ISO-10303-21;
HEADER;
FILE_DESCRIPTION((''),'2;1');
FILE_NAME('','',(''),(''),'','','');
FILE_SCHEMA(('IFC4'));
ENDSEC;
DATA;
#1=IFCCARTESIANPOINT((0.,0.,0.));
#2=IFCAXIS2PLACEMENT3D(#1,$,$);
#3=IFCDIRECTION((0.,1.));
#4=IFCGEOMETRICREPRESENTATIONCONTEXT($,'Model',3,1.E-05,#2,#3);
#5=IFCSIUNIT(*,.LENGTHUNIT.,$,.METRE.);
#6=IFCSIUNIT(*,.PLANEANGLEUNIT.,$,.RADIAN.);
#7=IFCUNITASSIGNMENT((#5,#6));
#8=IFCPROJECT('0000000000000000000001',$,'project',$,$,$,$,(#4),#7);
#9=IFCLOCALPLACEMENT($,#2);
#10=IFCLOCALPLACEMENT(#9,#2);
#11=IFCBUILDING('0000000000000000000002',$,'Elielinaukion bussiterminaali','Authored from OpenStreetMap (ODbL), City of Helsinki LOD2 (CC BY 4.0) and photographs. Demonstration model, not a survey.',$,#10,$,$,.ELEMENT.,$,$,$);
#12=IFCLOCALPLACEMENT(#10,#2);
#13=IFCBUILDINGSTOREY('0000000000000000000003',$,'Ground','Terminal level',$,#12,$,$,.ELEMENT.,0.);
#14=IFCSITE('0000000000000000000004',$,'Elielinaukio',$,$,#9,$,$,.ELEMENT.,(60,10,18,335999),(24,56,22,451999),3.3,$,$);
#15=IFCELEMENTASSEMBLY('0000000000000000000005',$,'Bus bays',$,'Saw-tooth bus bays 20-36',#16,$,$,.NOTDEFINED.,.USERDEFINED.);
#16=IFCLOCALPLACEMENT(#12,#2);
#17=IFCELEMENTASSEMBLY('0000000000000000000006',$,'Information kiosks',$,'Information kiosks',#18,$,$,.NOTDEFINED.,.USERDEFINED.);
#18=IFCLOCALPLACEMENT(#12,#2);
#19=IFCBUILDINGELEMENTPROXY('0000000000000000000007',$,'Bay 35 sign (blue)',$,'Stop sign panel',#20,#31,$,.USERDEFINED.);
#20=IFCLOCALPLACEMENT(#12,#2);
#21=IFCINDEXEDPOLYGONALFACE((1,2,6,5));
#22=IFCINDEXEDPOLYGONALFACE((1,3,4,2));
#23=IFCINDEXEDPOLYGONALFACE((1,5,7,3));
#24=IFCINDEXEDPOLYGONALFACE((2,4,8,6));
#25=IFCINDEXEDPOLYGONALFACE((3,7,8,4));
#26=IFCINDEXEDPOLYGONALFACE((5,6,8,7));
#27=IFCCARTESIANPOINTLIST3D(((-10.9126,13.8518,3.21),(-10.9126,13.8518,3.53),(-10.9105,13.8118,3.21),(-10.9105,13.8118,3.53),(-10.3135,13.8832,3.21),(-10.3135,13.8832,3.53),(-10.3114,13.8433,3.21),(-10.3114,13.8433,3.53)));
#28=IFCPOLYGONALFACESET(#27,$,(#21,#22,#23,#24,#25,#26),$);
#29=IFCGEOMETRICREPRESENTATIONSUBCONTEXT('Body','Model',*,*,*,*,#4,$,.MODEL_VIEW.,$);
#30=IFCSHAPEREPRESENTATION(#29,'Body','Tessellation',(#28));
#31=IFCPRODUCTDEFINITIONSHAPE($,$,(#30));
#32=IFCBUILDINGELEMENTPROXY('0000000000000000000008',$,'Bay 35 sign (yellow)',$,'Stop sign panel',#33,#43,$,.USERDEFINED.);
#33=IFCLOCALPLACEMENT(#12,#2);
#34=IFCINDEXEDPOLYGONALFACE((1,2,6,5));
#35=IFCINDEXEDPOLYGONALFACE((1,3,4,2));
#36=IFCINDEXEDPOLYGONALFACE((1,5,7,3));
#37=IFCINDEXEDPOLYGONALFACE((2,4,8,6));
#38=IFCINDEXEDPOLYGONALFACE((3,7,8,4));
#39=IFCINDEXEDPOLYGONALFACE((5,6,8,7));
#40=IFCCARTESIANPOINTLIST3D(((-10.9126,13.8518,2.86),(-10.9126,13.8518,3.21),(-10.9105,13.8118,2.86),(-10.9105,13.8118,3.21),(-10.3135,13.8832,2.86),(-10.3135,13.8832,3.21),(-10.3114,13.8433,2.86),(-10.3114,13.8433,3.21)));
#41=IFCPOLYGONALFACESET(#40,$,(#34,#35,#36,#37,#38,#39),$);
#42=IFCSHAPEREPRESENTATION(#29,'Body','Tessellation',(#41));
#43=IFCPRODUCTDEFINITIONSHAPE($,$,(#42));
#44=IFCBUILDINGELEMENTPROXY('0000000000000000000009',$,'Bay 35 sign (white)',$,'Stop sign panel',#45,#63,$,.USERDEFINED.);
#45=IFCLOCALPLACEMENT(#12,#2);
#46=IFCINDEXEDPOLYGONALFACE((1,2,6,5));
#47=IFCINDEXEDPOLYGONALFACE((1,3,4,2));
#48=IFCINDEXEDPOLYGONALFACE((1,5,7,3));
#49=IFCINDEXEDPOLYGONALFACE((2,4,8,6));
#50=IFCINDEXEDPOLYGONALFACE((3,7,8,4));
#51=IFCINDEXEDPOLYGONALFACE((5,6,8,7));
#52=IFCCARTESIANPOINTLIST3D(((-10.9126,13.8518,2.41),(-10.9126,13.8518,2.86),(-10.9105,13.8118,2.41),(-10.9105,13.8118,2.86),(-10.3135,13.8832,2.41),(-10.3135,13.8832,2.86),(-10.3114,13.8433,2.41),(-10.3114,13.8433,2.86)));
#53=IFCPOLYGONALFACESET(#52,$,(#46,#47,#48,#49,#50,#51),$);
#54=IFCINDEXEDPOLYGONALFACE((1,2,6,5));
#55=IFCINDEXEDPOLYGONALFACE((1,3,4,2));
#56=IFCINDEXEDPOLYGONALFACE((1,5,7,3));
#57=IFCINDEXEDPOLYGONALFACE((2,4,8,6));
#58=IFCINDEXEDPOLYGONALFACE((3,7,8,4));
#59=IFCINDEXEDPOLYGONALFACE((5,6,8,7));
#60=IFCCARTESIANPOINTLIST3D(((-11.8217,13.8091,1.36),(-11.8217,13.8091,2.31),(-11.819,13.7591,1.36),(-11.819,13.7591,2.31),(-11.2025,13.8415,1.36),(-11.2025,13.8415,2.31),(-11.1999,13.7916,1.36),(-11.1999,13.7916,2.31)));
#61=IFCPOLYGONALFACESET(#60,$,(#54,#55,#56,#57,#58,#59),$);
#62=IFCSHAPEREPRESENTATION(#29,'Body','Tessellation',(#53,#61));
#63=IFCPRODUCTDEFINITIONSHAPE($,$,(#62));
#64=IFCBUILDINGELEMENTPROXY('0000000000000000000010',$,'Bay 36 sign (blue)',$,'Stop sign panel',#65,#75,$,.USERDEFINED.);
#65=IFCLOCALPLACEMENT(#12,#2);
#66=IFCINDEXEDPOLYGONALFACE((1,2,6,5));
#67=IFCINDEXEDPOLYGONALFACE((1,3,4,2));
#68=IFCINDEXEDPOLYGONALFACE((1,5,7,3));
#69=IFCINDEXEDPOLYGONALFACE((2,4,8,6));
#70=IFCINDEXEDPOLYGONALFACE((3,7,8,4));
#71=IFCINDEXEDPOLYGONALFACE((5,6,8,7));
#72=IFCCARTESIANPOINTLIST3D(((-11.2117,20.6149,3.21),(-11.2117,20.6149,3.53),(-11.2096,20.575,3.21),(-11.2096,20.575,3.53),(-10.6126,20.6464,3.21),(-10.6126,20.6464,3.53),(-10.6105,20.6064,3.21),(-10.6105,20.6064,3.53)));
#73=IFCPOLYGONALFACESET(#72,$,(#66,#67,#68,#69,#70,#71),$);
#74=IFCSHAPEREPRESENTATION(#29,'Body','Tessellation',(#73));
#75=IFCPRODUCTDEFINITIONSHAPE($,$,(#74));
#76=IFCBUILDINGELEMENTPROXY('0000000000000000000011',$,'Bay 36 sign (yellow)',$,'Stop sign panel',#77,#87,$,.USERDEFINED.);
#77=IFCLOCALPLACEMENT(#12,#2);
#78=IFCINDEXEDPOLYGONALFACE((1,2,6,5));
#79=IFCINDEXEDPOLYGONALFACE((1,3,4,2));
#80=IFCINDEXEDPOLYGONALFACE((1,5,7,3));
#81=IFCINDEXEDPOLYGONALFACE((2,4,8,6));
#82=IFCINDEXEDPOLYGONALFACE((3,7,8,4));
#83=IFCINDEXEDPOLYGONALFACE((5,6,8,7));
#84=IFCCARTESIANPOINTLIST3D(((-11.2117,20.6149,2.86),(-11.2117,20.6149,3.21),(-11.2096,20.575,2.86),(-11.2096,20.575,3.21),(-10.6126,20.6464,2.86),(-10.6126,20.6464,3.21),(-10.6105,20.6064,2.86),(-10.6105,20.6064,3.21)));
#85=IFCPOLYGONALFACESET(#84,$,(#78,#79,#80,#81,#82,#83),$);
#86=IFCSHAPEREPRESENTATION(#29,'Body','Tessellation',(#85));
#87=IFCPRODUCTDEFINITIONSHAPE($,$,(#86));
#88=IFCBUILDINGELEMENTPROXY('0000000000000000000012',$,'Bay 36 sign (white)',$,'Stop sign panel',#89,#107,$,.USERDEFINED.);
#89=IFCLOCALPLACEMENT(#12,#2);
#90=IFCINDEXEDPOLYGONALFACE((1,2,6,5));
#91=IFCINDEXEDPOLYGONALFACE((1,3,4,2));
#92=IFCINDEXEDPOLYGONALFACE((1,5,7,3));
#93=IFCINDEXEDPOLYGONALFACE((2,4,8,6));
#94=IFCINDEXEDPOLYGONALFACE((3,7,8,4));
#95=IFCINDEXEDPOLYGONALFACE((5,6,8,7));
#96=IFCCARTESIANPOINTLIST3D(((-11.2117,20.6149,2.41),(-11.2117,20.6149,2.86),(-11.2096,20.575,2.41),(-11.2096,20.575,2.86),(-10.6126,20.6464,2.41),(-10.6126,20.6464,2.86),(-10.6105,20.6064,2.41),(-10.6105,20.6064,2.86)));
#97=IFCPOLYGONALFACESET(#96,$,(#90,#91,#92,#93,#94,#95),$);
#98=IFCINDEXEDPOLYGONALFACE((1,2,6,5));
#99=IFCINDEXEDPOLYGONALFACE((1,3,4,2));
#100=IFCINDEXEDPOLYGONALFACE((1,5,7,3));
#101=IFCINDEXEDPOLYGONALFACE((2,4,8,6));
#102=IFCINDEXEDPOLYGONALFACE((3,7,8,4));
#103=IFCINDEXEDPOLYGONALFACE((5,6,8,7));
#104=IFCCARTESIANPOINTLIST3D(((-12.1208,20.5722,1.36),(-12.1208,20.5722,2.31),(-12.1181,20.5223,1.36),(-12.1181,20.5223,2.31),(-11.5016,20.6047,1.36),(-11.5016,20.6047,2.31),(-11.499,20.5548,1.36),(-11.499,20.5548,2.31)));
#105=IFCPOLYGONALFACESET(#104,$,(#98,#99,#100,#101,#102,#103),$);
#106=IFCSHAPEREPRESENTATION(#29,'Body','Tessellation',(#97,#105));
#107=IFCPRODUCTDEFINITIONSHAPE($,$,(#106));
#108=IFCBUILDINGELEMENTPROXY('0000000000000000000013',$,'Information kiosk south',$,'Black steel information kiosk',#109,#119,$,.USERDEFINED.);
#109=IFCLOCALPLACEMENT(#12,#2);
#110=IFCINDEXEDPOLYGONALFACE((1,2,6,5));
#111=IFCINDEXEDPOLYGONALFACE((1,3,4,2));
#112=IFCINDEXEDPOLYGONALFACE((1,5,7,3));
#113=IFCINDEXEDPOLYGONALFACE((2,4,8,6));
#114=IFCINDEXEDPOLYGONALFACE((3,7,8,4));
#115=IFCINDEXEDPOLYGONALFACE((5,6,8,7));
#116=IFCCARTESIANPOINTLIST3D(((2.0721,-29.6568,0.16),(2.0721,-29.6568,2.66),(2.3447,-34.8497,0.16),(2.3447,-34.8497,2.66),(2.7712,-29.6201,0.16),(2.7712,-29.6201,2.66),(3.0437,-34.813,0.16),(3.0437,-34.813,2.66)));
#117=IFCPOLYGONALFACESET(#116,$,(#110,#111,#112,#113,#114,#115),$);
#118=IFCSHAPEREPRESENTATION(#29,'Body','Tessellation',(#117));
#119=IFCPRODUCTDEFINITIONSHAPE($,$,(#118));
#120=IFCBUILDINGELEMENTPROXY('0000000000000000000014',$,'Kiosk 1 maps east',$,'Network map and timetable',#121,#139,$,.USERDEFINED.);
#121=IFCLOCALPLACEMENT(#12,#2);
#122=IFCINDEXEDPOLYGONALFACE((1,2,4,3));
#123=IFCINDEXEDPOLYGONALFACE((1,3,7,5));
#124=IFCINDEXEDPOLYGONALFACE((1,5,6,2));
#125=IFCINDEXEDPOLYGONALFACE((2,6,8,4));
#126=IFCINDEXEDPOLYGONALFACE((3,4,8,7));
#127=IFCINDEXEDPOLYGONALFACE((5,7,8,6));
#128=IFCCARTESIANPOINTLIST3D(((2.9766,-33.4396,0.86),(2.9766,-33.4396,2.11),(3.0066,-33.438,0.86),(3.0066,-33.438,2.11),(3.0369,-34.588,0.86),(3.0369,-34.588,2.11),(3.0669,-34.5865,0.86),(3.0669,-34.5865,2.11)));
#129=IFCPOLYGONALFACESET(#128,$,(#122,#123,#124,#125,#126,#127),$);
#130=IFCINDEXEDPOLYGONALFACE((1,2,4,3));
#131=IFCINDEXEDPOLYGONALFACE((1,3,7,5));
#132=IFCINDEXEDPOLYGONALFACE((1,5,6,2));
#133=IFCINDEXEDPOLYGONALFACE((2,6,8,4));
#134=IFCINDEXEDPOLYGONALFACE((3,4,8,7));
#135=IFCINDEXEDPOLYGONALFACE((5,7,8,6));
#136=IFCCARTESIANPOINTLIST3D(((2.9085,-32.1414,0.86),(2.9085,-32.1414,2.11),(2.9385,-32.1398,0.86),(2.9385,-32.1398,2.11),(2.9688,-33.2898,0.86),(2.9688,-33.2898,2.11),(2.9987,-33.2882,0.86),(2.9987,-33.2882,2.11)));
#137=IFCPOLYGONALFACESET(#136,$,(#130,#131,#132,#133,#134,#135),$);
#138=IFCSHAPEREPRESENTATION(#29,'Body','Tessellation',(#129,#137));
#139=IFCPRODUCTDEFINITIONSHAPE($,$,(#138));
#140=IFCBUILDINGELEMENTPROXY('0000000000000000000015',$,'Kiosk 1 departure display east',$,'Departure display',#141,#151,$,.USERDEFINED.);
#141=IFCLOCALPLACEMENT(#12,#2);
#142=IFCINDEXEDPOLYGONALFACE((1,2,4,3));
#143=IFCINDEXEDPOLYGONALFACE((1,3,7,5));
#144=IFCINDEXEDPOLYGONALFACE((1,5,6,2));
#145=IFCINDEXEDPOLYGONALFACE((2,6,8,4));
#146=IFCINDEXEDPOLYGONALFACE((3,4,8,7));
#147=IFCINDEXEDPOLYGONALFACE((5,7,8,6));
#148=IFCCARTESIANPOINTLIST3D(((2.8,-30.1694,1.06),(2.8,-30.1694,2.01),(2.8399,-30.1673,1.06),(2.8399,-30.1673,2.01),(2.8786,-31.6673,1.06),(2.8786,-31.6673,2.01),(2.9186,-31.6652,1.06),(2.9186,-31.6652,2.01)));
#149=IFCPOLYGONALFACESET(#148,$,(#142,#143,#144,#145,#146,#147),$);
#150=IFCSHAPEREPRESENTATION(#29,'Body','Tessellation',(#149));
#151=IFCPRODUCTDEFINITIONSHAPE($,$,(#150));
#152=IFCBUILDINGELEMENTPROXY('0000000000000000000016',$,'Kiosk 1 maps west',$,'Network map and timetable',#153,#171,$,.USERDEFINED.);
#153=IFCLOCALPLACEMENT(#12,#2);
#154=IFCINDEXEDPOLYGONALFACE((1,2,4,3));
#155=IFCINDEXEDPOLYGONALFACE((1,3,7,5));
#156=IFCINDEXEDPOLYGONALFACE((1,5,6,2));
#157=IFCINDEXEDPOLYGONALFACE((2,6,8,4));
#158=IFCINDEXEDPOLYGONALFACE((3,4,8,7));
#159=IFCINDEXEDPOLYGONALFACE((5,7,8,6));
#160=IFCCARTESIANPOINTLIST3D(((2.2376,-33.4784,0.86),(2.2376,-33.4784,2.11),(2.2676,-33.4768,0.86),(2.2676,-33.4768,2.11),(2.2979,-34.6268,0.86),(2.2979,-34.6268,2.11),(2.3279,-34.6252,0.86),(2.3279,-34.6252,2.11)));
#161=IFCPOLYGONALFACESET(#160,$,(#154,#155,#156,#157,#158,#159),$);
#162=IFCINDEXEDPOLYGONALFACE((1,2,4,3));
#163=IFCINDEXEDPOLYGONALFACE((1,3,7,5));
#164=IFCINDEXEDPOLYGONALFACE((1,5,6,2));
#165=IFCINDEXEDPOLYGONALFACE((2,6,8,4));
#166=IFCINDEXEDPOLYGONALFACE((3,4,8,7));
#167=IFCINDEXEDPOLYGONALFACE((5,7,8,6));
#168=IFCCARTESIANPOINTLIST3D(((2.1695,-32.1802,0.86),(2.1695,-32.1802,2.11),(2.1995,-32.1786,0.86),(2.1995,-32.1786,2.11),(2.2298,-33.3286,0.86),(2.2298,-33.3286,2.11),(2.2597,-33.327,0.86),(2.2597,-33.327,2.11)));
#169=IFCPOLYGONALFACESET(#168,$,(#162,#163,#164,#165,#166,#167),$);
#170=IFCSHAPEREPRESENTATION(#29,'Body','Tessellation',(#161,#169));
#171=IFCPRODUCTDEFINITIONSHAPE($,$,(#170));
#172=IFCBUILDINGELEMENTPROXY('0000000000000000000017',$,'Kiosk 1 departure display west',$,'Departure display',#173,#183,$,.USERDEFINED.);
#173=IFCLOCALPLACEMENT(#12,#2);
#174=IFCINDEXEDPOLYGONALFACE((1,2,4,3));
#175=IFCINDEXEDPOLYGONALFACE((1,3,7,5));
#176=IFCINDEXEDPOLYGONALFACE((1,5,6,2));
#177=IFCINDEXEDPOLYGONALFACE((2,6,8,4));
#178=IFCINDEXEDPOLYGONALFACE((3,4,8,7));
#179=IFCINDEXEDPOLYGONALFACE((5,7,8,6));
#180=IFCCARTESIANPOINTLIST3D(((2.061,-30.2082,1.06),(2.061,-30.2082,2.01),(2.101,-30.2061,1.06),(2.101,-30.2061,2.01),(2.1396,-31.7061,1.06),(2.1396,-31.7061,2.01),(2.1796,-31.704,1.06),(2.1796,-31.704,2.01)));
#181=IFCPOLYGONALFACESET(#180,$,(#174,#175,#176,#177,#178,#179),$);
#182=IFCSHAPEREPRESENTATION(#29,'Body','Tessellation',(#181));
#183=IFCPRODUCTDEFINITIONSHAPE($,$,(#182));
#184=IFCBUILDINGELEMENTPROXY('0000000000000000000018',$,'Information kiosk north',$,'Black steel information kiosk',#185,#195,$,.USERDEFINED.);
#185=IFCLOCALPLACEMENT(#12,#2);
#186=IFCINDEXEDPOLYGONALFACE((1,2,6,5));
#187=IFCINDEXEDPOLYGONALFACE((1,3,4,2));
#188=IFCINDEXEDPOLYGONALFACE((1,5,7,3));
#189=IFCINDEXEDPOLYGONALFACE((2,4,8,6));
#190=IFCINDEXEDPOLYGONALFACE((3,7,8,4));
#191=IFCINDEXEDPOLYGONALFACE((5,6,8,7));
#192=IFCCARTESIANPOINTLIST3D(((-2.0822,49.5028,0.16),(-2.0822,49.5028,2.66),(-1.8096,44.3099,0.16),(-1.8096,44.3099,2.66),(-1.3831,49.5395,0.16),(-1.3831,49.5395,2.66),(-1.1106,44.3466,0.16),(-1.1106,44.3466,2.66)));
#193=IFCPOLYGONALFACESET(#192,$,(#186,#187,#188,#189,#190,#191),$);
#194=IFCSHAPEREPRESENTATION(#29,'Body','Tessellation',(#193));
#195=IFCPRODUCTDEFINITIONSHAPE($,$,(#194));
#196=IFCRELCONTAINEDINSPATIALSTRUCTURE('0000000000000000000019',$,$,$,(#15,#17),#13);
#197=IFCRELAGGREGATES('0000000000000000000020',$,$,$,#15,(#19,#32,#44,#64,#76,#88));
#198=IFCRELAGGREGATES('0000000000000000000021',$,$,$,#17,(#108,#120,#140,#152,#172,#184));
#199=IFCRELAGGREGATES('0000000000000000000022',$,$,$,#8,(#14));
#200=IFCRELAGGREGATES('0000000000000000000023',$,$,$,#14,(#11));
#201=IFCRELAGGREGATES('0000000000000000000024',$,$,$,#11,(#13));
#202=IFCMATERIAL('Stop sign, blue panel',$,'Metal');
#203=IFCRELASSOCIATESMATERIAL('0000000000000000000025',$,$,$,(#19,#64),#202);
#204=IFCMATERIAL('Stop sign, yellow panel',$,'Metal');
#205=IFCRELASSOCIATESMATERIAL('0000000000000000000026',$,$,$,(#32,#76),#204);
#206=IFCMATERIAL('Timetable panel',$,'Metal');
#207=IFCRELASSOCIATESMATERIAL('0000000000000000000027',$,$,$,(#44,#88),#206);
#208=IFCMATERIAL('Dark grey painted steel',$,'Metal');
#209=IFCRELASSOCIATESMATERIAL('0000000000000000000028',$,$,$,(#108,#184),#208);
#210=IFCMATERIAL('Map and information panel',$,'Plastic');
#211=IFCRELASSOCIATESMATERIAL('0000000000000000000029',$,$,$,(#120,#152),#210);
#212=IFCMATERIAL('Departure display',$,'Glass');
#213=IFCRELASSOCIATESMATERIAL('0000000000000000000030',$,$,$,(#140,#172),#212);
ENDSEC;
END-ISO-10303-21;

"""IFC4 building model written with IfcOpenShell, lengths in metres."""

from ifc_helpers import new_model, si_unit, direction, frame, frame_2d, origin, place, context, subcontext, project, spatial, rectangle, extrude, material, element, aggregate, save


model = new_model("IFC4")

# Units and contexts
model_context = context("Model", 3, precision=1e-05, world=origin(), true_north=direction((0.0, 1.0)))
body_context = subcontext(model_context, "Body", "Model", "MODEL_VIEW")
ifc_project = project(units=[si_unit("LENGTHUNIT", "METRE"), si_unit("PLANEANGLEUNIT", "RADIAN")], contexts=[model_context])

# Site, building, storey
site_placement = place(None, origin())
site = spatial("IfcSite", under=ifc_project, at=site_placement, Name="Elielinaukio", CompositionType="ELEMENT", RefLatitude=(60, 10, 18, 335999), RefLongitude=(24, 56, 22, 451999), RefElevation=3.3)
building_placement = place(site_placement, origin())
building = spatial("IfcBuilding", under=site, at=building_placement, Name="Elielinaukion bussiterminaali", Description="Authored from OpenStreetMap (ODbL), City of Helsinki LOD2 (CC BY 4.0) and photographs. Demonstration model, not a survey.", CompositionType="ELEMENT")
storey_placement = place(building_placement, origin())
storey = spatial("IfcBuildingStorey", under=building, at=storey_placement, Name="Ground", Description="Terminal level", CompositionType="ELEMENT", Elevation=0.0)

# Element assembly
assembly_1_placement = place(building_placement, origin())
assembly_1 = element("IfcElementAssembly", 1, at=assembly_1_placement, inside=storey, Name="Bus bays", ObjectType="Saw-tooth bus bays 20-36", AssemblyPlace="NOTDEFINED", PredefinedType="USERDEFINED")
ifc_material_1 = material(Name="Dark grey painted steel", Category="Metal")

# Element assembly
assembly_2_placement = place(building_placement, origin())
assembly_2 = element("IfcElementAssembly", 2, at=assembly_2_placement, inside=storey, Name="Information kiosks", ObjectType="Information kiosks", AssemblyPlace="NOTDEFINED", PredefinedType="USERDEFINED")

# Building element proxies
ifc_material_2 = material(Name="Stop sign, blue panel", Category="Metal")
ifc_material_3 = material(Name="Stop sign, yellow panel", Category="Metal")
ifc_material_4 = material(Name="Timetable panel", Category="Metal")
proxy_1_placement = place(building_placement, origin())
proxy_1 = element("IfcBuildingElementProxy", 3, at=proxy_1_placement, material=ifc_material_2, Name="Bay 35 sign (blue)", ObjectType="Stop sign panel", PredefinedType="USERDEFINED", context=body_context, shape_type="SweptSolid", body=[
    extrude(rectangle(XDim=0.04, YDim=0.6, at=frame_2d((0.0, 0.0), x_axis=(-0.052408, 0.998626))), frame((-10.612, 13.8475, 3.21)), (0.0, 0.0, 1.0), 0.32),
])
proxy_2_placement = place(building_placement, origin())
proxy_2 = element("IfcBuildingElementProxy", 4, at=proxy_2_placement, material=ifc_material_3, Name="Bay 35 sign (yellow)", ObjectType="Stop sign panel", PredefinedType="USERDEFINED", context=body_context, shape_type="SweptSolid", body=[
    extrude(rectangle(XDim=0.04, YDim=0.6, at=frame_2d((0.0, 0.0), x_axis=(-0.052408, 0.998626))), frame((-10.612, 13.8475, 2.86)), (0.0, 0.0, 1.0), 0.35),
])
proxy_3_placement = place(building_placement, origin())
proxy_3 = element("IfcBuildingElementProxy", 5, at=proxy_3_placement, material=ifc_material_4, Name="Bay 35 sign (white)", ObjectType="Stop sign panel", PredefinedType="USERDEFINED", context=body_context, shape_type="SweptSolid", body=[
    extrude(rectangle(XDim=0.04, YDim=0.6, at=frame_2d((0.0, 0.0), x_axis=(-0.052408, 0.998626))), frame((-10.612, 13.8475, 2.41)), (0.0, 0.0, 1.0), 0.45),
    extrude(rectangle(XDim=0.05, YDim=0.62, at=frame_2d((0.0, 0.0), x_axis=(-0.052408, 0.998626))), frame((-11.5108, 13.8003, 1.36)), (0.0, 0.0, 1.0), 0.95),
])
proxy_4_placement = place(building_placement, origin())
proxy_4 = element("IfcBuildingElementProxy", 6, at=proxy_4_placement, material=ifc_material_2, Name="Bay 36 sign (blue)", ObjectType="Stop sign panel", PredefinedType="USERDEFINED", context=body_context, shape_type="SweptSolid", body=[
    extrude(rectangle(XDim=0.04, YDim=0.6, at=frame_2d((0.0, 0.0), x_axis=(-0.052408, 0.998626))), frame((-10.9111, 20.6107, 3.21)), (0.0, 0.0, 1.0), 0.32),
])
proxy_5_placement = place(building_placement, origin())
proxy_5 = element("IfcBuildingElementProxy", 7, at=proxy_5_placement, material=ifc_material_3, Name="Bay 36 sign (yellow)", ObjectType="Stop sign panel", PredefinedType="USERDEFINED", context=body_context, shape_type="SweptSolid", body=[
    extrude(rectangle(XDim=0.04, YDim=0.6, at=frame_2d((0.0, 0.0), x_axis=(-0.052408, 0.998626))), frame((-10.9111, 20.6107, 2.86)), (0.0, 0.0, 1.0), 0.35),
])
proxy_6_placement = place(building_placement, origin())
proxy_6 = element("IfcBuildingElementProxy", 8, at=proxy_6_placement, material=ifc_material_4, Name="Bay 36 sign (white)", ObjectType="Stop sign panel", PredefinedType="USERDEFINED", context=body_context, shape_type="SweptSolid", body=[
    extrude(rectangle(XDim=0.04, YDim=0.6, at=frame_2d((0.0, 0.0), x_axis=(-0.052408, 0.998626))), frame((-10.9111, 20.6107, 2.41)), (0.0, 0.0, 1.0), 0.45),
    extrude(rectangle(XDim=0.05, YDim=0.62, at=frame_2d((0.0, 0.0), x_axis=(-0.052408, 0.998626))), frame((-11.8099, 20.5635, 1.36)), (0.0, 0.0, 1.0), 0.95),
])
aggregate(assembly_1, [proxy_1, proxy_2, proxy_3, proxy_4, proxy_5, proxy_6])
proxy_7_placement = place(building_placement, origin())
proxy_7 = element("IfcBuildingElementProxy", 9, at=proxy_7_placement, material=ifc_material_1, Name="Information kiosk south", ObjectType="Black steel information kiosk", PredefinedType="USERDEFINED", context=body_context, shape_type="SweptSolid", body=[
    extrude(rectangle(XDim=5.2, YDim=0.7, at=frame_2d((0.0, 0.0), x_axis=(-0.052408, 0.998626))), frame((2.5579, -32.2349, 0.16)), (0.0, 0.0, 1.0), 2.5),
])
ifc_material_5 = material(Name="Map and information panel", Category="Plastic")
proxy_8_placement = place(building_placement, origin())
proxy_8 = element("IfcBuildingElementProxy", 10, at=proxy_8_placement, material=ifc_material_5, Name="Kiosk 1 maps east", ObjectType="Network map and timetable", PredefinedType="USERDEFINED", context=body_context, shape_type="SweptSolid", body=[
    extrude(rectangle(XDim=1.15, YDim=0.03, at=frame_2d((0.0, 0.0), x_axis=(-0.052408, 0.998626))), frame((3.0217, -34.013, 0.86)), (0.0, 0.0, 1.0), 1.25),
    extrude(rectangle(XDim=1.15, YDim=0.03, at=frame_2d((0.0, 0.0), x_axis=(-0.052408, 0.998626))), frame((2.9536, -32.7148, 0.86)), (0.0, 0.0, 1.0), 1.25),
])
ifc_material_6 = material(Name="Departure display", Category="Glass")
proxy_9_placement = place(building_placement, origin())
proxy_9 = element("IfcBuildingElementProxy", 11, at=proxy_9_placement, material=ifc_material_6, Name="Kiosk 1 departure display east", ObjectType="Departure display", PredefinedType="USERDEFINED", context=body_context, shape_type="SweptSolid", body=[
    extrude(rectangle(XDim=1.5, YDim=0.04, at=frame_2d((0.0, 0.0), x_axis=(-0.052408, 0.998626))), frame((2.8593, -30.9173, 1.06)), (0.0, 0.0, 1.0), 0.95),
])
proxy_10_placement = place(building_placement, origin())
proxy_10 = element("IfcBuildingElementProxy", 12, at=proxy_10_placement, material=ifc_material_5, Name="Kiosk 1 maps west", ObjectType="Network map and timetable", PredefinedType="USERDEFINED", context=body_context, shape_type="SweptSolid", body=[
    extrude(rectangle(XDim=1.15, YDim=0.03, at=frame_2d((0.0, 0.0), x_axis=(-0.052408, 0.998626))), frame((2.2828, -34.0518, 0.86)), (0.0, 0.0, 1.0), 1.25),
    extrude(rectangle(XDim=1.15, YDim=0.03, at=frame_2d((0.0, 0.0), x_axis=(-0.052408, 0.998626))), frame((2.2146, -32.7536, 0.86)), (0.0, 0.0, 1.0), 1.25),
])
proxy_11_placement = place(building_placement, origin())
proxy_11 = element("IfcBuildingElementProxy", 13, at=proxy_11_placement, material=ifc_material_6, Name="Kiosk 1 departure display west", ObjectType="Departure display", PredefinedType="USERDEFINED", context=body_context, shape_type="SweptSolid", body=[
    extrude(rectangle(XDim=1.5, YDim=0.04, at=frame_2d((0.0, 0.0), x_axis=(-0.052408, 0.998626))), frame((2.1203, -30.9561, 1.06)), (0.0, 0.0, 1.0), 0.95),
])
proxy_12_placement = place(building_placement, origin())
proxy_12 = element("IfcBuildingElementProxy", 14, at=proxy_12_placement, material=ifc_material_1, Name="Information kiosk north", ObjectType="Black steel information kiosk", PredefinedType="USERDEFINED", context=body_context, shape_type="SweptSolid", body=[
    extrude(rectangle(XDim=5.2, YDim=0.7, at=frame_2d((0.0, 0.0), x_axis=(-0.052408, 0.998626))), frame((-1.5964, 46.9247, 0.16)), (0.0, 0.0, 1.0), 2.5),
])
aggregate(assembly_2, [proxy_7, proxy_8, proxy_9, proxy_10, proxy_11, proxy_12])

save(model, "model.ifc")
